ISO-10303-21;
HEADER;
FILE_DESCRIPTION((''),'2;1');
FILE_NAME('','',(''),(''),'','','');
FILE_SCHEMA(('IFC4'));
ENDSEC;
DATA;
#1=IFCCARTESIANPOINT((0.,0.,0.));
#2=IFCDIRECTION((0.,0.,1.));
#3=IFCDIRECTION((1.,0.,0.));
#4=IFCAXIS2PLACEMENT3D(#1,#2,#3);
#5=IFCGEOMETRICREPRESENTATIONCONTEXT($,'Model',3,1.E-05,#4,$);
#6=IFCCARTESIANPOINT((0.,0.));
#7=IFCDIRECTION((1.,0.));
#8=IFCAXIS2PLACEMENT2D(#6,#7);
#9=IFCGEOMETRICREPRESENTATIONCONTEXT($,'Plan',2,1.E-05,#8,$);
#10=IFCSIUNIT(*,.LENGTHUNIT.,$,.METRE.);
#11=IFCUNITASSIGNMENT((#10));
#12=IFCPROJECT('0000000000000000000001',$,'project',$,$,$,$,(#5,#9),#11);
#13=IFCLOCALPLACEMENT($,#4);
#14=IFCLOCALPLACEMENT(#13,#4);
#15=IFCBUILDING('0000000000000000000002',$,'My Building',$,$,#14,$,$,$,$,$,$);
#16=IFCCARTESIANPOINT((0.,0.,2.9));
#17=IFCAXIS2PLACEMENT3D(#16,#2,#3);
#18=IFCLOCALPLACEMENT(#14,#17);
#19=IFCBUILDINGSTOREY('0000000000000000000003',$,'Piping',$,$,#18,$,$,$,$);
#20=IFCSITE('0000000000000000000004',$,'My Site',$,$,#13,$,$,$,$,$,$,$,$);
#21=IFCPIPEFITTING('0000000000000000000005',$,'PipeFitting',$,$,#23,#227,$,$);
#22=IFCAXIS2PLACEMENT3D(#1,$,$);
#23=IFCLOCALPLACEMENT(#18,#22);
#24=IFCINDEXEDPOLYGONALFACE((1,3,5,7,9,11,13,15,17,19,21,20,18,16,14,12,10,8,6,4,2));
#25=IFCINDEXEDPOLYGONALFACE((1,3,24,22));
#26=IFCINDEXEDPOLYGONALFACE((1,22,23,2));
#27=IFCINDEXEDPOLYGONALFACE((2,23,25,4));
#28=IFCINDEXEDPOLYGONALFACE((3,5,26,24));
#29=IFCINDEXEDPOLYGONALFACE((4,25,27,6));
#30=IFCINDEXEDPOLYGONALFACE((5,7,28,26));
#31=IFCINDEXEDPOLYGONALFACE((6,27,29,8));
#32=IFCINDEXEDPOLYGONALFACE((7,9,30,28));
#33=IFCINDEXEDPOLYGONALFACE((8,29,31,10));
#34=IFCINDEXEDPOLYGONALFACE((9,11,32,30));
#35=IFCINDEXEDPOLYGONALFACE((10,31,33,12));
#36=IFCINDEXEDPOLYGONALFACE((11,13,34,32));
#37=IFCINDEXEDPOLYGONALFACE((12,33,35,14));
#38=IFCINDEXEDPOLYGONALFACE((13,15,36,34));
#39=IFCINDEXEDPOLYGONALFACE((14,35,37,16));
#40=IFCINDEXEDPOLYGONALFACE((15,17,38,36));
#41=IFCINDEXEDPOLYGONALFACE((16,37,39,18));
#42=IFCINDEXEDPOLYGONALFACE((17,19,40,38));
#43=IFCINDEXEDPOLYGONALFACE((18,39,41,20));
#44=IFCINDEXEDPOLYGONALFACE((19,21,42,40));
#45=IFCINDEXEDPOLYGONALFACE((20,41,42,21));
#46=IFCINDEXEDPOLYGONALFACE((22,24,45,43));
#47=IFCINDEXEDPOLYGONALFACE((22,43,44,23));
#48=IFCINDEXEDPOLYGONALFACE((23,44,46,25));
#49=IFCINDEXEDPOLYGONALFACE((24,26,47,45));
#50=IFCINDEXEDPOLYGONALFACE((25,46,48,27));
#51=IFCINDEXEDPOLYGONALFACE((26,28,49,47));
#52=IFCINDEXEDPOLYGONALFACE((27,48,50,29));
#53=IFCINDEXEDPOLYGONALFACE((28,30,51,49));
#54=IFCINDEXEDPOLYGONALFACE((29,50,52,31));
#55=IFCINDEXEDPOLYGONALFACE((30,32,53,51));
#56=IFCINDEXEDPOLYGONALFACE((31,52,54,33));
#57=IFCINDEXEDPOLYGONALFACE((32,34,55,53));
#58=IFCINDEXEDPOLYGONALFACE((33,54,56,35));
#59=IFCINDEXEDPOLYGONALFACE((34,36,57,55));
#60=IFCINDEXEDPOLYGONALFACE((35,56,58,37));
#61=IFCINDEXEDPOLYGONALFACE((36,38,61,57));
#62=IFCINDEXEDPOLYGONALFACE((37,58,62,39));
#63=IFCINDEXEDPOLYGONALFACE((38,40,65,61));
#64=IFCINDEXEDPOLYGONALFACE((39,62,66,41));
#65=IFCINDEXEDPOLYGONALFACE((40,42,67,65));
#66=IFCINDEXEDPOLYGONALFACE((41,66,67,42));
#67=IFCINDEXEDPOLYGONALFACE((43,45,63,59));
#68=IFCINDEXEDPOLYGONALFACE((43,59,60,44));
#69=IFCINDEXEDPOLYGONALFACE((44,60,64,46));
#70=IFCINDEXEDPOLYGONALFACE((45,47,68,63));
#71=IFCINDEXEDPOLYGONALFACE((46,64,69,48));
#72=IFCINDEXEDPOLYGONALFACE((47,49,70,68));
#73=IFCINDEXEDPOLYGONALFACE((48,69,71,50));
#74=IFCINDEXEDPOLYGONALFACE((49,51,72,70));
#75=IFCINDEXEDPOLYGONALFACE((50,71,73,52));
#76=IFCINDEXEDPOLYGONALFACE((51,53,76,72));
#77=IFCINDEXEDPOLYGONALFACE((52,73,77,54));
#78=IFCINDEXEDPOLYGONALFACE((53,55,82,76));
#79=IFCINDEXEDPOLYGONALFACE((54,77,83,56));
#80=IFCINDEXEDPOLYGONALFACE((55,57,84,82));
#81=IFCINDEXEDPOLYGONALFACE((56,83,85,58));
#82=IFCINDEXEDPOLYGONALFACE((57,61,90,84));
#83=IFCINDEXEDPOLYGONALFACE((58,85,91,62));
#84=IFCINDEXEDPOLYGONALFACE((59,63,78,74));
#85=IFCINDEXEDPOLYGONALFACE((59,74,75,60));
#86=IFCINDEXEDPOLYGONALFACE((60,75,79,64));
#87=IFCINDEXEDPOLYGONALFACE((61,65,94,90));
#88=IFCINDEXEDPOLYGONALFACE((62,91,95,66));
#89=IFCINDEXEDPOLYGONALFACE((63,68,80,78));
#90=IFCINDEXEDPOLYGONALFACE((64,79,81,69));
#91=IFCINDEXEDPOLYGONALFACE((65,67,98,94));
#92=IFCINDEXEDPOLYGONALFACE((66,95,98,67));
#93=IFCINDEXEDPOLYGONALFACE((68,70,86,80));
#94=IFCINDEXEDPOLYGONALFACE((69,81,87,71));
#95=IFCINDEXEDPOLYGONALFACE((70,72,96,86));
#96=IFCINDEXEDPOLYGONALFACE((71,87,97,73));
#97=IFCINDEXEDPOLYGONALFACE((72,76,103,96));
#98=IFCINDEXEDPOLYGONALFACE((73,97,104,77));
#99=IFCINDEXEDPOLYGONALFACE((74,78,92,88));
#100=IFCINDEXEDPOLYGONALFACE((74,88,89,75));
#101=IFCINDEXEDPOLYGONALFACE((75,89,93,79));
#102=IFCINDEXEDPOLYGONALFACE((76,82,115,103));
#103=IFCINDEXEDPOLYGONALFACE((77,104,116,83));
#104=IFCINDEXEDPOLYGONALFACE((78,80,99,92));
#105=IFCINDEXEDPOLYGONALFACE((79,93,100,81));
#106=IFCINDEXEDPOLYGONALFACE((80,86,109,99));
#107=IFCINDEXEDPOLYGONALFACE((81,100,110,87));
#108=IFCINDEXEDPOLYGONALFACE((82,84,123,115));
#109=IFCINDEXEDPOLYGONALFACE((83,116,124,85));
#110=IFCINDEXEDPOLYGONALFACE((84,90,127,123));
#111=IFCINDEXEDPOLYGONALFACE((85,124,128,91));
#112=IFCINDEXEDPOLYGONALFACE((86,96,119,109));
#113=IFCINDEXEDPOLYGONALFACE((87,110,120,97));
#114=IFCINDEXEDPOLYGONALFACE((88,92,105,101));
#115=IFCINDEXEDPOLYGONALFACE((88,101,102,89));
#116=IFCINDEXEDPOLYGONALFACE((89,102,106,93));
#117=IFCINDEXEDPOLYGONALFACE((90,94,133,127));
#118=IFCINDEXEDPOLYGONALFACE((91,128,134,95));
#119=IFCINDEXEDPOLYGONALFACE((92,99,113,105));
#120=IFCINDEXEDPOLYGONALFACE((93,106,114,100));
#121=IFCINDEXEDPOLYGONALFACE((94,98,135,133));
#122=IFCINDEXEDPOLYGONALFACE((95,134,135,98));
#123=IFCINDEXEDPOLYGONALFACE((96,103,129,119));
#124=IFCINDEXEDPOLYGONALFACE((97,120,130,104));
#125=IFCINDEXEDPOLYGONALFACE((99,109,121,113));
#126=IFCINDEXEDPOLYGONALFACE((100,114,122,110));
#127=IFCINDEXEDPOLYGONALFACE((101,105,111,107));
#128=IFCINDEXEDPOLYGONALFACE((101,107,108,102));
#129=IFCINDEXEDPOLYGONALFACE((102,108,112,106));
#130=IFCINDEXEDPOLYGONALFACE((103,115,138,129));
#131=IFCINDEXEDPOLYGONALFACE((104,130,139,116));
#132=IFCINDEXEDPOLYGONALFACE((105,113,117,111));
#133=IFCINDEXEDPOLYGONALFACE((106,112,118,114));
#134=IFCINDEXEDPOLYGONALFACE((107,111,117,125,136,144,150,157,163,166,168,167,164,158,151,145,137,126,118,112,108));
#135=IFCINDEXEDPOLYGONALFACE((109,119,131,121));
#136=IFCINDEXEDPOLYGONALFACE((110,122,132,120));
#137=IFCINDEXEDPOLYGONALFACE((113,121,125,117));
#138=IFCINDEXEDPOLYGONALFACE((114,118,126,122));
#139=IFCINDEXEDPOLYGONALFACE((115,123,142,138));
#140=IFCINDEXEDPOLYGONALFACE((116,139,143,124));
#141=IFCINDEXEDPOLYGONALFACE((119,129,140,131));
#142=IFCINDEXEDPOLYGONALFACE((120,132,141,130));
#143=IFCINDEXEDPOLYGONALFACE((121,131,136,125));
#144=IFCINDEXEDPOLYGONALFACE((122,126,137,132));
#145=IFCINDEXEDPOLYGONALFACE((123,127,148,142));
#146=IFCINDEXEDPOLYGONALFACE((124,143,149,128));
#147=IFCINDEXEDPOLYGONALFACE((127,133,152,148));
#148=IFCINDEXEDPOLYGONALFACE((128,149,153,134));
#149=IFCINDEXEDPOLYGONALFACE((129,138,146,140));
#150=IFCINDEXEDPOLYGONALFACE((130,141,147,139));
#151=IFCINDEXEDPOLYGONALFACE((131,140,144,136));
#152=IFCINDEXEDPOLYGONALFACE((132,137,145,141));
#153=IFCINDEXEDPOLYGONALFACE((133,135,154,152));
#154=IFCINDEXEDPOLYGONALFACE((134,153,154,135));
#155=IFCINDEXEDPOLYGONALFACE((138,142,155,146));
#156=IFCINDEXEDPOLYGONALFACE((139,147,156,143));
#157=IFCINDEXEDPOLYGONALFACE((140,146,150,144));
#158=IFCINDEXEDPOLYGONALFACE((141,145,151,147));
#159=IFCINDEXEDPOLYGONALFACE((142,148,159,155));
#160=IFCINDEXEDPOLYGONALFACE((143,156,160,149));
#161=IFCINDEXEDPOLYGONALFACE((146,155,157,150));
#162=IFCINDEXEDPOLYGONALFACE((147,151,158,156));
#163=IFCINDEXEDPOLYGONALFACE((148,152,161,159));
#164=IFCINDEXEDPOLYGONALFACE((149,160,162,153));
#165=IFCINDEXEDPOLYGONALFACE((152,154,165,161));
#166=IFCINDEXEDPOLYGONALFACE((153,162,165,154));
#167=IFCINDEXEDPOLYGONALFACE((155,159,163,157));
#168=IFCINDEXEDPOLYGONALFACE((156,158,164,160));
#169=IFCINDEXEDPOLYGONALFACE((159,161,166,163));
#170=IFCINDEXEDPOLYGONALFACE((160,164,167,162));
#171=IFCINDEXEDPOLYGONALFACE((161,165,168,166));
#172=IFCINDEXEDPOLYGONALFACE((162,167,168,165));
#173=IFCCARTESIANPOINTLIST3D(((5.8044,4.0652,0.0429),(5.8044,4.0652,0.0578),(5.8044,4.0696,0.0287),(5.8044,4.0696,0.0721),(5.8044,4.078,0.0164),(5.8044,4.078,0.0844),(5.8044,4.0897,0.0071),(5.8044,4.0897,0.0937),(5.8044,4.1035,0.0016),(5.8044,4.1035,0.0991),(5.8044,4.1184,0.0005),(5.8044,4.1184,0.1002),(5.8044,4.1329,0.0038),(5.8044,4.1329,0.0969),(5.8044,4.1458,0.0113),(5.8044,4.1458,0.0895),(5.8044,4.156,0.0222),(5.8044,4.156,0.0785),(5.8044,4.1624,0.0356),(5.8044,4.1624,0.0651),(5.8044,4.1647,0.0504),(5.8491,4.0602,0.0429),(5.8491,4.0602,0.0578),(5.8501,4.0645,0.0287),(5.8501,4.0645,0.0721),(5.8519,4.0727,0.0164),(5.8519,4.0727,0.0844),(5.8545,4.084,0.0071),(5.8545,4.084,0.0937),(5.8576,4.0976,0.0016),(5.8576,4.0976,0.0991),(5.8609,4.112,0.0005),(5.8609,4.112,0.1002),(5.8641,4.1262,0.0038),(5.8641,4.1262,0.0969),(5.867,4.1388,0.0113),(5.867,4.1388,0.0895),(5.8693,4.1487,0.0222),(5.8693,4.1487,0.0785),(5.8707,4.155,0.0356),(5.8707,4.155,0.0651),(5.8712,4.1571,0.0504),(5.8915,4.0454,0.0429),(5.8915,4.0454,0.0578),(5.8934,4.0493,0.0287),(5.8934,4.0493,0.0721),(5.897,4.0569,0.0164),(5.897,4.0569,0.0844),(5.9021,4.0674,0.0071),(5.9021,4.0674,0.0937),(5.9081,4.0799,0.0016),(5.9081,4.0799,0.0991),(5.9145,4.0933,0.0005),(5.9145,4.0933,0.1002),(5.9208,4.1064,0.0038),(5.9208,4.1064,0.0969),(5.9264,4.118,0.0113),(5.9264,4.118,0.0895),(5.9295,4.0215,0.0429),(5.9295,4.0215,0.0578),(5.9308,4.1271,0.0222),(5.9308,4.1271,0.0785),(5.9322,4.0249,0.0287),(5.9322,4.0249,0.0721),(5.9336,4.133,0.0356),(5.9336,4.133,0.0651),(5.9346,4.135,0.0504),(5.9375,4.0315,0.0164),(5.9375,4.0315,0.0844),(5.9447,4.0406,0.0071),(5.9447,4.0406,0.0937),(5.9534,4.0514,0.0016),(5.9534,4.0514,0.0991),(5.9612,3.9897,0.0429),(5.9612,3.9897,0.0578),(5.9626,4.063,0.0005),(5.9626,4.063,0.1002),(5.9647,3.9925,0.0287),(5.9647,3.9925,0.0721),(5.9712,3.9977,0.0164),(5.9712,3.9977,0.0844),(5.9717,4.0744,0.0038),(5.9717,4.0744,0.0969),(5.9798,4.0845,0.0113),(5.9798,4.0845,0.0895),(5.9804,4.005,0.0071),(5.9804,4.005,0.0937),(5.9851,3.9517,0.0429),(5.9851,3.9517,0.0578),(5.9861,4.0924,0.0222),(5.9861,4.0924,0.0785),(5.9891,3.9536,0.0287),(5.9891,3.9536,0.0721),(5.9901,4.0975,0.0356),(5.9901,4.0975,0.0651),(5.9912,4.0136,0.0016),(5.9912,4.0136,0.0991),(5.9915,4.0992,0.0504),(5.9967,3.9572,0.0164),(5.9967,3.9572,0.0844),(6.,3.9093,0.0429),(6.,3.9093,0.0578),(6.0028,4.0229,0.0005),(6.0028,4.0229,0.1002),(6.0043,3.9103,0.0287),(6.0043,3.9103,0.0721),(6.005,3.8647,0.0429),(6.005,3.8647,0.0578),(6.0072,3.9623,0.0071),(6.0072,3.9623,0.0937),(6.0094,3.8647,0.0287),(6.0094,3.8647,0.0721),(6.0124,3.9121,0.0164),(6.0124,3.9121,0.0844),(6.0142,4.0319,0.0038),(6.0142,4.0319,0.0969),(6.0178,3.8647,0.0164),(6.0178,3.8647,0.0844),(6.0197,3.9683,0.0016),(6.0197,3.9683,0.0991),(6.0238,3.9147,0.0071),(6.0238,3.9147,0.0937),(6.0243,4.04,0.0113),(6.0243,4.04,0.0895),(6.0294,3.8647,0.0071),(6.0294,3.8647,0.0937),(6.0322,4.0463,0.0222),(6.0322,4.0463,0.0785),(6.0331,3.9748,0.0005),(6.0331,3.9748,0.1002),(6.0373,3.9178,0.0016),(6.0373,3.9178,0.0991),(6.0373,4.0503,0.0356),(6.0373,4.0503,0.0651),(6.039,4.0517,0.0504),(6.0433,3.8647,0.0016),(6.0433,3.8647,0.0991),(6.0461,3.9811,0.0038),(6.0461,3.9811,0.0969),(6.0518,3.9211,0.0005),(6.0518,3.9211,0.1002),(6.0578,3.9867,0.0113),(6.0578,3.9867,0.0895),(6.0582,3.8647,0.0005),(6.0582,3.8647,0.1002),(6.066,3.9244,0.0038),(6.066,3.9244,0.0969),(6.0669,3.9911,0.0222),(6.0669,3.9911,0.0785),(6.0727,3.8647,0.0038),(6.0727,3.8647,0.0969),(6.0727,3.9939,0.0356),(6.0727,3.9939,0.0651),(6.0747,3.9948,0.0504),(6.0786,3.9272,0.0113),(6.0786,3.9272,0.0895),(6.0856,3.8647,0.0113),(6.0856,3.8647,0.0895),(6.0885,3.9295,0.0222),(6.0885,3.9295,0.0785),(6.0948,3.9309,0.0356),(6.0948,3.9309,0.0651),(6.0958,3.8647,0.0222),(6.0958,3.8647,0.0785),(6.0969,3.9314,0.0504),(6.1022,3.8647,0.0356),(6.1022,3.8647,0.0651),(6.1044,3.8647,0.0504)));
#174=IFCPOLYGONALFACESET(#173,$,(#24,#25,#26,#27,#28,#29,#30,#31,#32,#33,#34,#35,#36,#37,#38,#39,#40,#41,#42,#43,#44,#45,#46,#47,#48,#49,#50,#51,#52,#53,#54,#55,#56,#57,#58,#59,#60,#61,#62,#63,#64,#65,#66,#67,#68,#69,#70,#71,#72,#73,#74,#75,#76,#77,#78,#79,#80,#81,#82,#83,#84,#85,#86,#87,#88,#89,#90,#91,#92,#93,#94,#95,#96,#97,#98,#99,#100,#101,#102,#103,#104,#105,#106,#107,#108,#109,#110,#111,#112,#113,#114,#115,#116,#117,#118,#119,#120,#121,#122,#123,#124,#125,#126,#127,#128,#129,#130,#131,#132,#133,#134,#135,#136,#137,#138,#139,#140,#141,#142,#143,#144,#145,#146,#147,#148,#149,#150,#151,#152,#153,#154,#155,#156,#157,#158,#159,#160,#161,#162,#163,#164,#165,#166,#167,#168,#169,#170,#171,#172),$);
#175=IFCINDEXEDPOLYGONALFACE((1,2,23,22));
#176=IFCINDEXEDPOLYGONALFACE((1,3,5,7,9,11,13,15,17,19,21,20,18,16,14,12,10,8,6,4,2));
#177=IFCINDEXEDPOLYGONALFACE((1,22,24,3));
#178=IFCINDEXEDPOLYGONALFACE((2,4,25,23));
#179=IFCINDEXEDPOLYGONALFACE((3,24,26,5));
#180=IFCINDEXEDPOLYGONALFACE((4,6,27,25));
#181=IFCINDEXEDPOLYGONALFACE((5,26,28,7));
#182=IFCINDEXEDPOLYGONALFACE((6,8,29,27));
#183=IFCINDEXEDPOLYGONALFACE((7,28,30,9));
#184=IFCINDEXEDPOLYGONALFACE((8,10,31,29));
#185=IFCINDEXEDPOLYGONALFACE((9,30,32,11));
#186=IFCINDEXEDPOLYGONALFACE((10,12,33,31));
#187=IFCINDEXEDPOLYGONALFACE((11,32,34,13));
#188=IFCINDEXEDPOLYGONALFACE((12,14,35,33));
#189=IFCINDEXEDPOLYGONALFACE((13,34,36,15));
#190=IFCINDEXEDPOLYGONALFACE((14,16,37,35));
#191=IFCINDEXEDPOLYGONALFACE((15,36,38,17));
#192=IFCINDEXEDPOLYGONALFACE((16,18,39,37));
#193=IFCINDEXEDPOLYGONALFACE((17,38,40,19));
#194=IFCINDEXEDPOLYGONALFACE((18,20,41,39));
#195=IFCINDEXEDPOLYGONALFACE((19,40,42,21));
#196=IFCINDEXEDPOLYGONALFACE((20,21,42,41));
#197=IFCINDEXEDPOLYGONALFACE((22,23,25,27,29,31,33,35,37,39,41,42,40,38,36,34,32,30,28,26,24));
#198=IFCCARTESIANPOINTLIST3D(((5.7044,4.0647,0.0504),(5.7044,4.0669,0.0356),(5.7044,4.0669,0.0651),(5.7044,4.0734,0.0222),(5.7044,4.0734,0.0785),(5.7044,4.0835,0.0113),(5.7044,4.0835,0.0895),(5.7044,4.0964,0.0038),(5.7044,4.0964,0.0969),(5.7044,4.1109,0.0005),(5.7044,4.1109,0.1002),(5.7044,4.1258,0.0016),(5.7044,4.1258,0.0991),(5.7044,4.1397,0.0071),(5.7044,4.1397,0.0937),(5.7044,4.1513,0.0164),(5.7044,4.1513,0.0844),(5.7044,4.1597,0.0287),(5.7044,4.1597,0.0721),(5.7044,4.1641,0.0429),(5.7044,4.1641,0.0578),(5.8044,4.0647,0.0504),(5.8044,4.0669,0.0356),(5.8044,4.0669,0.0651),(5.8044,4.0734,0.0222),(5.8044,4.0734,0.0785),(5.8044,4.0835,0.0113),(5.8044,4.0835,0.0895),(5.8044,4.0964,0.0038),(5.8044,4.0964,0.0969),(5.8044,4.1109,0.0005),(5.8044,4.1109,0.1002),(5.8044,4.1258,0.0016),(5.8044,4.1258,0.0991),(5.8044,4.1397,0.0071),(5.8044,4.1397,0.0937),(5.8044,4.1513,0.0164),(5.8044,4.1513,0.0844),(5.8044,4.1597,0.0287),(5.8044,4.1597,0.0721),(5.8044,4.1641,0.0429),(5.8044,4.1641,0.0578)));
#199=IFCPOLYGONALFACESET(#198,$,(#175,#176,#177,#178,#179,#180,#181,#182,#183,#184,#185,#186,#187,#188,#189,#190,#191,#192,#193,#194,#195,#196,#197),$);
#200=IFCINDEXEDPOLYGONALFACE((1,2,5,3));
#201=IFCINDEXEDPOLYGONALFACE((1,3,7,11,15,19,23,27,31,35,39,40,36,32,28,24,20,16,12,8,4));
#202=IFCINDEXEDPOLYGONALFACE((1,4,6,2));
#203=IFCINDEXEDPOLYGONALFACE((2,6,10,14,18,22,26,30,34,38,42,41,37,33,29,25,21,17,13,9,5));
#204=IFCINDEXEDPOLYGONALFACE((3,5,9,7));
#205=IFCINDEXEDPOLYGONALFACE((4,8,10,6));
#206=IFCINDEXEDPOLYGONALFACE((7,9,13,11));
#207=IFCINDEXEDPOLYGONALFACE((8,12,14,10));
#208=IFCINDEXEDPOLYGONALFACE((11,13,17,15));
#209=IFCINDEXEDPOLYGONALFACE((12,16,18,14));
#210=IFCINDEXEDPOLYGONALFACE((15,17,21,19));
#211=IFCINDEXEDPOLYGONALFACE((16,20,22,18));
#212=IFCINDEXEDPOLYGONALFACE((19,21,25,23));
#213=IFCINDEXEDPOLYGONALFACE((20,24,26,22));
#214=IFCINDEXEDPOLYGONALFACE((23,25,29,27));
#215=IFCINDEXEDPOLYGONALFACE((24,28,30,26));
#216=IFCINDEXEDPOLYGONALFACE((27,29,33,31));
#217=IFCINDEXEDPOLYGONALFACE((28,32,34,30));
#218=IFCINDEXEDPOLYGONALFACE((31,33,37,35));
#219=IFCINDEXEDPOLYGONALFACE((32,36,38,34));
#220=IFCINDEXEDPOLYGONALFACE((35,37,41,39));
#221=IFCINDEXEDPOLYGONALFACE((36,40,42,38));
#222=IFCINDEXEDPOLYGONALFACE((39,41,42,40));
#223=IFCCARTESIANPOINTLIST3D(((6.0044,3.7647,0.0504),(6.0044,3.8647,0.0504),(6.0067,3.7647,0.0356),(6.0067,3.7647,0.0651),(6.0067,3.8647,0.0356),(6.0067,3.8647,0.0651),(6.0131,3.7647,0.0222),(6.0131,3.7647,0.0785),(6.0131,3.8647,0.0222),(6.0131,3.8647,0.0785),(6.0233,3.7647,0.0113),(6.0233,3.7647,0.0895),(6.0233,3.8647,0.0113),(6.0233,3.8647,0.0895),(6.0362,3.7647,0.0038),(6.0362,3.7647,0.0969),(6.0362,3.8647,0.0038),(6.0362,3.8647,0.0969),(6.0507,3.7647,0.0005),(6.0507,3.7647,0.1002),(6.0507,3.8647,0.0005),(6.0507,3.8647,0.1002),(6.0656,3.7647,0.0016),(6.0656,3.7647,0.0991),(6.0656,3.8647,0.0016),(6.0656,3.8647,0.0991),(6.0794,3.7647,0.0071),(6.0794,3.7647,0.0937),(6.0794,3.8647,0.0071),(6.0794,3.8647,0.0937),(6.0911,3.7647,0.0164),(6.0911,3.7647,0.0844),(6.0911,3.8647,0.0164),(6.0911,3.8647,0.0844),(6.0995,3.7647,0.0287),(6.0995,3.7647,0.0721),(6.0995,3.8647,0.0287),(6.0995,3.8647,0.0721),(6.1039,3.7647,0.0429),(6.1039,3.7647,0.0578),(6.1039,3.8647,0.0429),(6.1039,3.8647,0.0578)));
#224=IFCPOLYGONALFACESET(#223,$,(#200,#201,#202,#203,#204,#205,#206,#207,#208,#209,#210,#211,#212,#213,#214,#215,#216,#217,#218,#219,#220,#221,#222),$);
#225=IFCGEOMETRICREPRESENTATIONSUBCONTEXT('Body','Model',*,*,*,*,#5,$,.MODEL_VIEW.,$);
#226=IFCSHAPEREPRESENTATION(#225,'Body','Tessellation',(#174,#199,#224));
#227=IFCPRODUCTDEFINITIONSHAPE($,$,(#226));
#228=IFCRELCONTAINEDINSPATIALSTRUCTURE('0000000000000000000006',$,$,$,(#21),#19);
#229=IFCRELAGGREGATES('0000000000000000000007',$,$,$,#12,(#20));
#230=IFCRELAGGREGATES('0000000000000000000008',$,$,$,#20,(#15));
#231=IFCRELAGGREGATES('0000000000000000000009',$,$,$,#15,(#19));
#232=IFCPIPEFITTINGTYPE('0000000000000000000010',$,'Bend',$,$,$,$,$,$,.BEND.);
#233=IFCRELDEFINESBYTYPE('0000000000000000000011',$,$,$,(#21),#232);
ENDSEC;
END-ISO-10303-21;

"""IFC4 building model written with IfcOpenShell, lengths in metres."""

from ifc_helpers import new_model, entity, si_unit, frame, origin_with_axes, origin_2d_with_axis, place, context, subcontext, project, spatial, circle, extrude, source, transform, mapped, type_object, type_shapes, element, save


model = new_model("IFC4")

# Units and contexts
model_context = context("Model", 3, precision=1e-05, world=origin_with_axes())
plan_context = context("Plan", 2, precision=1e-05, world=origin_2d_with_axis())
body_context = subcontext(model_context, "Body", "Model", "MODEL_VIEW")
ifc_project = project(units=[si_unit("LENGTHUNIT", "METRE")], contexts=[model_context, plan_context])

# Site, building, storey
site_placement = place(None, origin_with_axes())
site = spatial("IfcSite", under=ifc_project, at=site_placement, Name="My Site")
building_placement = place(site_placement, origin_with_axes())
building = spatial("IfcBuilding", under=site, at=building_placement, Name="My Building")
storey_placement = place(building_placement, frame((0.0, 0.0, 2.9), z_axis=(0.0, 0.0, 1.0), x_axis=(1.0, 0.0, 0.0)))
storey = spatial("IfcBuildingStorey", under=building, at=storey_placement, Name="Piping")

# Pipe fitting
pipe_fitting_type_1 = type_object("IfcPipeFittingType", Name="Bend", PredefinedType="BEND")
shared_shape = source(origin_with_axes(), body_context, "Body", "SolidModel", [
    entity("IfcSweptDiskSolid", entity("IfcIndexedPolyCurve", entity("IfcCartesianPointList3D", [[0.0, 0.0, -0.1], [0.0732, 0.0, -0.2768], [0.25, 0.0, -0.35]]), [entity("IfcArcIndex", [1, 2, 3])]), 0.05),
    extrude(circle(Radius=0.05), origin_with_axes(), (0.0, 0.0, -1.0), 0.1),
    extrude(circle(Radius=0.05), frame((0.25, 0.0, -0.35), z_axis=(1.0, 0.0, 0.0), x_axis=(0.0, 0.0, 1.0)), (0.0, 0.0, 1.0), 0.1),
])
type_shapes(pipe_fitting_type_1, [shared_shape])
for number, where, z_axis, x_axis, name in (
    (1, (5.7044, 4.1147, 0.0504), (-1.0, 0.000001, -0.000001), (-0.000001, -1.0, 0.0), "PipeFitting"),
):
    element("IfcPipeFitting", number, at=place(storey_placement, frame(where, z_axis=z_axis, x_axis=x_axis)), inside=storey, type_object=pipe_fitting_type_1, Name=name, context=body_context, shape_type="MappedRepresentation", body=[
        mapped(shared_shape, transform((0.0, 0.0, 0.0), x_axis=(1.0, 0.0, 0.0), y_axis=(0.0, 1.0, 0.0), z_axis=(0.0, 0.0, 1.0), scale=1.0)),
    ])

save(model, "model.ifc")
